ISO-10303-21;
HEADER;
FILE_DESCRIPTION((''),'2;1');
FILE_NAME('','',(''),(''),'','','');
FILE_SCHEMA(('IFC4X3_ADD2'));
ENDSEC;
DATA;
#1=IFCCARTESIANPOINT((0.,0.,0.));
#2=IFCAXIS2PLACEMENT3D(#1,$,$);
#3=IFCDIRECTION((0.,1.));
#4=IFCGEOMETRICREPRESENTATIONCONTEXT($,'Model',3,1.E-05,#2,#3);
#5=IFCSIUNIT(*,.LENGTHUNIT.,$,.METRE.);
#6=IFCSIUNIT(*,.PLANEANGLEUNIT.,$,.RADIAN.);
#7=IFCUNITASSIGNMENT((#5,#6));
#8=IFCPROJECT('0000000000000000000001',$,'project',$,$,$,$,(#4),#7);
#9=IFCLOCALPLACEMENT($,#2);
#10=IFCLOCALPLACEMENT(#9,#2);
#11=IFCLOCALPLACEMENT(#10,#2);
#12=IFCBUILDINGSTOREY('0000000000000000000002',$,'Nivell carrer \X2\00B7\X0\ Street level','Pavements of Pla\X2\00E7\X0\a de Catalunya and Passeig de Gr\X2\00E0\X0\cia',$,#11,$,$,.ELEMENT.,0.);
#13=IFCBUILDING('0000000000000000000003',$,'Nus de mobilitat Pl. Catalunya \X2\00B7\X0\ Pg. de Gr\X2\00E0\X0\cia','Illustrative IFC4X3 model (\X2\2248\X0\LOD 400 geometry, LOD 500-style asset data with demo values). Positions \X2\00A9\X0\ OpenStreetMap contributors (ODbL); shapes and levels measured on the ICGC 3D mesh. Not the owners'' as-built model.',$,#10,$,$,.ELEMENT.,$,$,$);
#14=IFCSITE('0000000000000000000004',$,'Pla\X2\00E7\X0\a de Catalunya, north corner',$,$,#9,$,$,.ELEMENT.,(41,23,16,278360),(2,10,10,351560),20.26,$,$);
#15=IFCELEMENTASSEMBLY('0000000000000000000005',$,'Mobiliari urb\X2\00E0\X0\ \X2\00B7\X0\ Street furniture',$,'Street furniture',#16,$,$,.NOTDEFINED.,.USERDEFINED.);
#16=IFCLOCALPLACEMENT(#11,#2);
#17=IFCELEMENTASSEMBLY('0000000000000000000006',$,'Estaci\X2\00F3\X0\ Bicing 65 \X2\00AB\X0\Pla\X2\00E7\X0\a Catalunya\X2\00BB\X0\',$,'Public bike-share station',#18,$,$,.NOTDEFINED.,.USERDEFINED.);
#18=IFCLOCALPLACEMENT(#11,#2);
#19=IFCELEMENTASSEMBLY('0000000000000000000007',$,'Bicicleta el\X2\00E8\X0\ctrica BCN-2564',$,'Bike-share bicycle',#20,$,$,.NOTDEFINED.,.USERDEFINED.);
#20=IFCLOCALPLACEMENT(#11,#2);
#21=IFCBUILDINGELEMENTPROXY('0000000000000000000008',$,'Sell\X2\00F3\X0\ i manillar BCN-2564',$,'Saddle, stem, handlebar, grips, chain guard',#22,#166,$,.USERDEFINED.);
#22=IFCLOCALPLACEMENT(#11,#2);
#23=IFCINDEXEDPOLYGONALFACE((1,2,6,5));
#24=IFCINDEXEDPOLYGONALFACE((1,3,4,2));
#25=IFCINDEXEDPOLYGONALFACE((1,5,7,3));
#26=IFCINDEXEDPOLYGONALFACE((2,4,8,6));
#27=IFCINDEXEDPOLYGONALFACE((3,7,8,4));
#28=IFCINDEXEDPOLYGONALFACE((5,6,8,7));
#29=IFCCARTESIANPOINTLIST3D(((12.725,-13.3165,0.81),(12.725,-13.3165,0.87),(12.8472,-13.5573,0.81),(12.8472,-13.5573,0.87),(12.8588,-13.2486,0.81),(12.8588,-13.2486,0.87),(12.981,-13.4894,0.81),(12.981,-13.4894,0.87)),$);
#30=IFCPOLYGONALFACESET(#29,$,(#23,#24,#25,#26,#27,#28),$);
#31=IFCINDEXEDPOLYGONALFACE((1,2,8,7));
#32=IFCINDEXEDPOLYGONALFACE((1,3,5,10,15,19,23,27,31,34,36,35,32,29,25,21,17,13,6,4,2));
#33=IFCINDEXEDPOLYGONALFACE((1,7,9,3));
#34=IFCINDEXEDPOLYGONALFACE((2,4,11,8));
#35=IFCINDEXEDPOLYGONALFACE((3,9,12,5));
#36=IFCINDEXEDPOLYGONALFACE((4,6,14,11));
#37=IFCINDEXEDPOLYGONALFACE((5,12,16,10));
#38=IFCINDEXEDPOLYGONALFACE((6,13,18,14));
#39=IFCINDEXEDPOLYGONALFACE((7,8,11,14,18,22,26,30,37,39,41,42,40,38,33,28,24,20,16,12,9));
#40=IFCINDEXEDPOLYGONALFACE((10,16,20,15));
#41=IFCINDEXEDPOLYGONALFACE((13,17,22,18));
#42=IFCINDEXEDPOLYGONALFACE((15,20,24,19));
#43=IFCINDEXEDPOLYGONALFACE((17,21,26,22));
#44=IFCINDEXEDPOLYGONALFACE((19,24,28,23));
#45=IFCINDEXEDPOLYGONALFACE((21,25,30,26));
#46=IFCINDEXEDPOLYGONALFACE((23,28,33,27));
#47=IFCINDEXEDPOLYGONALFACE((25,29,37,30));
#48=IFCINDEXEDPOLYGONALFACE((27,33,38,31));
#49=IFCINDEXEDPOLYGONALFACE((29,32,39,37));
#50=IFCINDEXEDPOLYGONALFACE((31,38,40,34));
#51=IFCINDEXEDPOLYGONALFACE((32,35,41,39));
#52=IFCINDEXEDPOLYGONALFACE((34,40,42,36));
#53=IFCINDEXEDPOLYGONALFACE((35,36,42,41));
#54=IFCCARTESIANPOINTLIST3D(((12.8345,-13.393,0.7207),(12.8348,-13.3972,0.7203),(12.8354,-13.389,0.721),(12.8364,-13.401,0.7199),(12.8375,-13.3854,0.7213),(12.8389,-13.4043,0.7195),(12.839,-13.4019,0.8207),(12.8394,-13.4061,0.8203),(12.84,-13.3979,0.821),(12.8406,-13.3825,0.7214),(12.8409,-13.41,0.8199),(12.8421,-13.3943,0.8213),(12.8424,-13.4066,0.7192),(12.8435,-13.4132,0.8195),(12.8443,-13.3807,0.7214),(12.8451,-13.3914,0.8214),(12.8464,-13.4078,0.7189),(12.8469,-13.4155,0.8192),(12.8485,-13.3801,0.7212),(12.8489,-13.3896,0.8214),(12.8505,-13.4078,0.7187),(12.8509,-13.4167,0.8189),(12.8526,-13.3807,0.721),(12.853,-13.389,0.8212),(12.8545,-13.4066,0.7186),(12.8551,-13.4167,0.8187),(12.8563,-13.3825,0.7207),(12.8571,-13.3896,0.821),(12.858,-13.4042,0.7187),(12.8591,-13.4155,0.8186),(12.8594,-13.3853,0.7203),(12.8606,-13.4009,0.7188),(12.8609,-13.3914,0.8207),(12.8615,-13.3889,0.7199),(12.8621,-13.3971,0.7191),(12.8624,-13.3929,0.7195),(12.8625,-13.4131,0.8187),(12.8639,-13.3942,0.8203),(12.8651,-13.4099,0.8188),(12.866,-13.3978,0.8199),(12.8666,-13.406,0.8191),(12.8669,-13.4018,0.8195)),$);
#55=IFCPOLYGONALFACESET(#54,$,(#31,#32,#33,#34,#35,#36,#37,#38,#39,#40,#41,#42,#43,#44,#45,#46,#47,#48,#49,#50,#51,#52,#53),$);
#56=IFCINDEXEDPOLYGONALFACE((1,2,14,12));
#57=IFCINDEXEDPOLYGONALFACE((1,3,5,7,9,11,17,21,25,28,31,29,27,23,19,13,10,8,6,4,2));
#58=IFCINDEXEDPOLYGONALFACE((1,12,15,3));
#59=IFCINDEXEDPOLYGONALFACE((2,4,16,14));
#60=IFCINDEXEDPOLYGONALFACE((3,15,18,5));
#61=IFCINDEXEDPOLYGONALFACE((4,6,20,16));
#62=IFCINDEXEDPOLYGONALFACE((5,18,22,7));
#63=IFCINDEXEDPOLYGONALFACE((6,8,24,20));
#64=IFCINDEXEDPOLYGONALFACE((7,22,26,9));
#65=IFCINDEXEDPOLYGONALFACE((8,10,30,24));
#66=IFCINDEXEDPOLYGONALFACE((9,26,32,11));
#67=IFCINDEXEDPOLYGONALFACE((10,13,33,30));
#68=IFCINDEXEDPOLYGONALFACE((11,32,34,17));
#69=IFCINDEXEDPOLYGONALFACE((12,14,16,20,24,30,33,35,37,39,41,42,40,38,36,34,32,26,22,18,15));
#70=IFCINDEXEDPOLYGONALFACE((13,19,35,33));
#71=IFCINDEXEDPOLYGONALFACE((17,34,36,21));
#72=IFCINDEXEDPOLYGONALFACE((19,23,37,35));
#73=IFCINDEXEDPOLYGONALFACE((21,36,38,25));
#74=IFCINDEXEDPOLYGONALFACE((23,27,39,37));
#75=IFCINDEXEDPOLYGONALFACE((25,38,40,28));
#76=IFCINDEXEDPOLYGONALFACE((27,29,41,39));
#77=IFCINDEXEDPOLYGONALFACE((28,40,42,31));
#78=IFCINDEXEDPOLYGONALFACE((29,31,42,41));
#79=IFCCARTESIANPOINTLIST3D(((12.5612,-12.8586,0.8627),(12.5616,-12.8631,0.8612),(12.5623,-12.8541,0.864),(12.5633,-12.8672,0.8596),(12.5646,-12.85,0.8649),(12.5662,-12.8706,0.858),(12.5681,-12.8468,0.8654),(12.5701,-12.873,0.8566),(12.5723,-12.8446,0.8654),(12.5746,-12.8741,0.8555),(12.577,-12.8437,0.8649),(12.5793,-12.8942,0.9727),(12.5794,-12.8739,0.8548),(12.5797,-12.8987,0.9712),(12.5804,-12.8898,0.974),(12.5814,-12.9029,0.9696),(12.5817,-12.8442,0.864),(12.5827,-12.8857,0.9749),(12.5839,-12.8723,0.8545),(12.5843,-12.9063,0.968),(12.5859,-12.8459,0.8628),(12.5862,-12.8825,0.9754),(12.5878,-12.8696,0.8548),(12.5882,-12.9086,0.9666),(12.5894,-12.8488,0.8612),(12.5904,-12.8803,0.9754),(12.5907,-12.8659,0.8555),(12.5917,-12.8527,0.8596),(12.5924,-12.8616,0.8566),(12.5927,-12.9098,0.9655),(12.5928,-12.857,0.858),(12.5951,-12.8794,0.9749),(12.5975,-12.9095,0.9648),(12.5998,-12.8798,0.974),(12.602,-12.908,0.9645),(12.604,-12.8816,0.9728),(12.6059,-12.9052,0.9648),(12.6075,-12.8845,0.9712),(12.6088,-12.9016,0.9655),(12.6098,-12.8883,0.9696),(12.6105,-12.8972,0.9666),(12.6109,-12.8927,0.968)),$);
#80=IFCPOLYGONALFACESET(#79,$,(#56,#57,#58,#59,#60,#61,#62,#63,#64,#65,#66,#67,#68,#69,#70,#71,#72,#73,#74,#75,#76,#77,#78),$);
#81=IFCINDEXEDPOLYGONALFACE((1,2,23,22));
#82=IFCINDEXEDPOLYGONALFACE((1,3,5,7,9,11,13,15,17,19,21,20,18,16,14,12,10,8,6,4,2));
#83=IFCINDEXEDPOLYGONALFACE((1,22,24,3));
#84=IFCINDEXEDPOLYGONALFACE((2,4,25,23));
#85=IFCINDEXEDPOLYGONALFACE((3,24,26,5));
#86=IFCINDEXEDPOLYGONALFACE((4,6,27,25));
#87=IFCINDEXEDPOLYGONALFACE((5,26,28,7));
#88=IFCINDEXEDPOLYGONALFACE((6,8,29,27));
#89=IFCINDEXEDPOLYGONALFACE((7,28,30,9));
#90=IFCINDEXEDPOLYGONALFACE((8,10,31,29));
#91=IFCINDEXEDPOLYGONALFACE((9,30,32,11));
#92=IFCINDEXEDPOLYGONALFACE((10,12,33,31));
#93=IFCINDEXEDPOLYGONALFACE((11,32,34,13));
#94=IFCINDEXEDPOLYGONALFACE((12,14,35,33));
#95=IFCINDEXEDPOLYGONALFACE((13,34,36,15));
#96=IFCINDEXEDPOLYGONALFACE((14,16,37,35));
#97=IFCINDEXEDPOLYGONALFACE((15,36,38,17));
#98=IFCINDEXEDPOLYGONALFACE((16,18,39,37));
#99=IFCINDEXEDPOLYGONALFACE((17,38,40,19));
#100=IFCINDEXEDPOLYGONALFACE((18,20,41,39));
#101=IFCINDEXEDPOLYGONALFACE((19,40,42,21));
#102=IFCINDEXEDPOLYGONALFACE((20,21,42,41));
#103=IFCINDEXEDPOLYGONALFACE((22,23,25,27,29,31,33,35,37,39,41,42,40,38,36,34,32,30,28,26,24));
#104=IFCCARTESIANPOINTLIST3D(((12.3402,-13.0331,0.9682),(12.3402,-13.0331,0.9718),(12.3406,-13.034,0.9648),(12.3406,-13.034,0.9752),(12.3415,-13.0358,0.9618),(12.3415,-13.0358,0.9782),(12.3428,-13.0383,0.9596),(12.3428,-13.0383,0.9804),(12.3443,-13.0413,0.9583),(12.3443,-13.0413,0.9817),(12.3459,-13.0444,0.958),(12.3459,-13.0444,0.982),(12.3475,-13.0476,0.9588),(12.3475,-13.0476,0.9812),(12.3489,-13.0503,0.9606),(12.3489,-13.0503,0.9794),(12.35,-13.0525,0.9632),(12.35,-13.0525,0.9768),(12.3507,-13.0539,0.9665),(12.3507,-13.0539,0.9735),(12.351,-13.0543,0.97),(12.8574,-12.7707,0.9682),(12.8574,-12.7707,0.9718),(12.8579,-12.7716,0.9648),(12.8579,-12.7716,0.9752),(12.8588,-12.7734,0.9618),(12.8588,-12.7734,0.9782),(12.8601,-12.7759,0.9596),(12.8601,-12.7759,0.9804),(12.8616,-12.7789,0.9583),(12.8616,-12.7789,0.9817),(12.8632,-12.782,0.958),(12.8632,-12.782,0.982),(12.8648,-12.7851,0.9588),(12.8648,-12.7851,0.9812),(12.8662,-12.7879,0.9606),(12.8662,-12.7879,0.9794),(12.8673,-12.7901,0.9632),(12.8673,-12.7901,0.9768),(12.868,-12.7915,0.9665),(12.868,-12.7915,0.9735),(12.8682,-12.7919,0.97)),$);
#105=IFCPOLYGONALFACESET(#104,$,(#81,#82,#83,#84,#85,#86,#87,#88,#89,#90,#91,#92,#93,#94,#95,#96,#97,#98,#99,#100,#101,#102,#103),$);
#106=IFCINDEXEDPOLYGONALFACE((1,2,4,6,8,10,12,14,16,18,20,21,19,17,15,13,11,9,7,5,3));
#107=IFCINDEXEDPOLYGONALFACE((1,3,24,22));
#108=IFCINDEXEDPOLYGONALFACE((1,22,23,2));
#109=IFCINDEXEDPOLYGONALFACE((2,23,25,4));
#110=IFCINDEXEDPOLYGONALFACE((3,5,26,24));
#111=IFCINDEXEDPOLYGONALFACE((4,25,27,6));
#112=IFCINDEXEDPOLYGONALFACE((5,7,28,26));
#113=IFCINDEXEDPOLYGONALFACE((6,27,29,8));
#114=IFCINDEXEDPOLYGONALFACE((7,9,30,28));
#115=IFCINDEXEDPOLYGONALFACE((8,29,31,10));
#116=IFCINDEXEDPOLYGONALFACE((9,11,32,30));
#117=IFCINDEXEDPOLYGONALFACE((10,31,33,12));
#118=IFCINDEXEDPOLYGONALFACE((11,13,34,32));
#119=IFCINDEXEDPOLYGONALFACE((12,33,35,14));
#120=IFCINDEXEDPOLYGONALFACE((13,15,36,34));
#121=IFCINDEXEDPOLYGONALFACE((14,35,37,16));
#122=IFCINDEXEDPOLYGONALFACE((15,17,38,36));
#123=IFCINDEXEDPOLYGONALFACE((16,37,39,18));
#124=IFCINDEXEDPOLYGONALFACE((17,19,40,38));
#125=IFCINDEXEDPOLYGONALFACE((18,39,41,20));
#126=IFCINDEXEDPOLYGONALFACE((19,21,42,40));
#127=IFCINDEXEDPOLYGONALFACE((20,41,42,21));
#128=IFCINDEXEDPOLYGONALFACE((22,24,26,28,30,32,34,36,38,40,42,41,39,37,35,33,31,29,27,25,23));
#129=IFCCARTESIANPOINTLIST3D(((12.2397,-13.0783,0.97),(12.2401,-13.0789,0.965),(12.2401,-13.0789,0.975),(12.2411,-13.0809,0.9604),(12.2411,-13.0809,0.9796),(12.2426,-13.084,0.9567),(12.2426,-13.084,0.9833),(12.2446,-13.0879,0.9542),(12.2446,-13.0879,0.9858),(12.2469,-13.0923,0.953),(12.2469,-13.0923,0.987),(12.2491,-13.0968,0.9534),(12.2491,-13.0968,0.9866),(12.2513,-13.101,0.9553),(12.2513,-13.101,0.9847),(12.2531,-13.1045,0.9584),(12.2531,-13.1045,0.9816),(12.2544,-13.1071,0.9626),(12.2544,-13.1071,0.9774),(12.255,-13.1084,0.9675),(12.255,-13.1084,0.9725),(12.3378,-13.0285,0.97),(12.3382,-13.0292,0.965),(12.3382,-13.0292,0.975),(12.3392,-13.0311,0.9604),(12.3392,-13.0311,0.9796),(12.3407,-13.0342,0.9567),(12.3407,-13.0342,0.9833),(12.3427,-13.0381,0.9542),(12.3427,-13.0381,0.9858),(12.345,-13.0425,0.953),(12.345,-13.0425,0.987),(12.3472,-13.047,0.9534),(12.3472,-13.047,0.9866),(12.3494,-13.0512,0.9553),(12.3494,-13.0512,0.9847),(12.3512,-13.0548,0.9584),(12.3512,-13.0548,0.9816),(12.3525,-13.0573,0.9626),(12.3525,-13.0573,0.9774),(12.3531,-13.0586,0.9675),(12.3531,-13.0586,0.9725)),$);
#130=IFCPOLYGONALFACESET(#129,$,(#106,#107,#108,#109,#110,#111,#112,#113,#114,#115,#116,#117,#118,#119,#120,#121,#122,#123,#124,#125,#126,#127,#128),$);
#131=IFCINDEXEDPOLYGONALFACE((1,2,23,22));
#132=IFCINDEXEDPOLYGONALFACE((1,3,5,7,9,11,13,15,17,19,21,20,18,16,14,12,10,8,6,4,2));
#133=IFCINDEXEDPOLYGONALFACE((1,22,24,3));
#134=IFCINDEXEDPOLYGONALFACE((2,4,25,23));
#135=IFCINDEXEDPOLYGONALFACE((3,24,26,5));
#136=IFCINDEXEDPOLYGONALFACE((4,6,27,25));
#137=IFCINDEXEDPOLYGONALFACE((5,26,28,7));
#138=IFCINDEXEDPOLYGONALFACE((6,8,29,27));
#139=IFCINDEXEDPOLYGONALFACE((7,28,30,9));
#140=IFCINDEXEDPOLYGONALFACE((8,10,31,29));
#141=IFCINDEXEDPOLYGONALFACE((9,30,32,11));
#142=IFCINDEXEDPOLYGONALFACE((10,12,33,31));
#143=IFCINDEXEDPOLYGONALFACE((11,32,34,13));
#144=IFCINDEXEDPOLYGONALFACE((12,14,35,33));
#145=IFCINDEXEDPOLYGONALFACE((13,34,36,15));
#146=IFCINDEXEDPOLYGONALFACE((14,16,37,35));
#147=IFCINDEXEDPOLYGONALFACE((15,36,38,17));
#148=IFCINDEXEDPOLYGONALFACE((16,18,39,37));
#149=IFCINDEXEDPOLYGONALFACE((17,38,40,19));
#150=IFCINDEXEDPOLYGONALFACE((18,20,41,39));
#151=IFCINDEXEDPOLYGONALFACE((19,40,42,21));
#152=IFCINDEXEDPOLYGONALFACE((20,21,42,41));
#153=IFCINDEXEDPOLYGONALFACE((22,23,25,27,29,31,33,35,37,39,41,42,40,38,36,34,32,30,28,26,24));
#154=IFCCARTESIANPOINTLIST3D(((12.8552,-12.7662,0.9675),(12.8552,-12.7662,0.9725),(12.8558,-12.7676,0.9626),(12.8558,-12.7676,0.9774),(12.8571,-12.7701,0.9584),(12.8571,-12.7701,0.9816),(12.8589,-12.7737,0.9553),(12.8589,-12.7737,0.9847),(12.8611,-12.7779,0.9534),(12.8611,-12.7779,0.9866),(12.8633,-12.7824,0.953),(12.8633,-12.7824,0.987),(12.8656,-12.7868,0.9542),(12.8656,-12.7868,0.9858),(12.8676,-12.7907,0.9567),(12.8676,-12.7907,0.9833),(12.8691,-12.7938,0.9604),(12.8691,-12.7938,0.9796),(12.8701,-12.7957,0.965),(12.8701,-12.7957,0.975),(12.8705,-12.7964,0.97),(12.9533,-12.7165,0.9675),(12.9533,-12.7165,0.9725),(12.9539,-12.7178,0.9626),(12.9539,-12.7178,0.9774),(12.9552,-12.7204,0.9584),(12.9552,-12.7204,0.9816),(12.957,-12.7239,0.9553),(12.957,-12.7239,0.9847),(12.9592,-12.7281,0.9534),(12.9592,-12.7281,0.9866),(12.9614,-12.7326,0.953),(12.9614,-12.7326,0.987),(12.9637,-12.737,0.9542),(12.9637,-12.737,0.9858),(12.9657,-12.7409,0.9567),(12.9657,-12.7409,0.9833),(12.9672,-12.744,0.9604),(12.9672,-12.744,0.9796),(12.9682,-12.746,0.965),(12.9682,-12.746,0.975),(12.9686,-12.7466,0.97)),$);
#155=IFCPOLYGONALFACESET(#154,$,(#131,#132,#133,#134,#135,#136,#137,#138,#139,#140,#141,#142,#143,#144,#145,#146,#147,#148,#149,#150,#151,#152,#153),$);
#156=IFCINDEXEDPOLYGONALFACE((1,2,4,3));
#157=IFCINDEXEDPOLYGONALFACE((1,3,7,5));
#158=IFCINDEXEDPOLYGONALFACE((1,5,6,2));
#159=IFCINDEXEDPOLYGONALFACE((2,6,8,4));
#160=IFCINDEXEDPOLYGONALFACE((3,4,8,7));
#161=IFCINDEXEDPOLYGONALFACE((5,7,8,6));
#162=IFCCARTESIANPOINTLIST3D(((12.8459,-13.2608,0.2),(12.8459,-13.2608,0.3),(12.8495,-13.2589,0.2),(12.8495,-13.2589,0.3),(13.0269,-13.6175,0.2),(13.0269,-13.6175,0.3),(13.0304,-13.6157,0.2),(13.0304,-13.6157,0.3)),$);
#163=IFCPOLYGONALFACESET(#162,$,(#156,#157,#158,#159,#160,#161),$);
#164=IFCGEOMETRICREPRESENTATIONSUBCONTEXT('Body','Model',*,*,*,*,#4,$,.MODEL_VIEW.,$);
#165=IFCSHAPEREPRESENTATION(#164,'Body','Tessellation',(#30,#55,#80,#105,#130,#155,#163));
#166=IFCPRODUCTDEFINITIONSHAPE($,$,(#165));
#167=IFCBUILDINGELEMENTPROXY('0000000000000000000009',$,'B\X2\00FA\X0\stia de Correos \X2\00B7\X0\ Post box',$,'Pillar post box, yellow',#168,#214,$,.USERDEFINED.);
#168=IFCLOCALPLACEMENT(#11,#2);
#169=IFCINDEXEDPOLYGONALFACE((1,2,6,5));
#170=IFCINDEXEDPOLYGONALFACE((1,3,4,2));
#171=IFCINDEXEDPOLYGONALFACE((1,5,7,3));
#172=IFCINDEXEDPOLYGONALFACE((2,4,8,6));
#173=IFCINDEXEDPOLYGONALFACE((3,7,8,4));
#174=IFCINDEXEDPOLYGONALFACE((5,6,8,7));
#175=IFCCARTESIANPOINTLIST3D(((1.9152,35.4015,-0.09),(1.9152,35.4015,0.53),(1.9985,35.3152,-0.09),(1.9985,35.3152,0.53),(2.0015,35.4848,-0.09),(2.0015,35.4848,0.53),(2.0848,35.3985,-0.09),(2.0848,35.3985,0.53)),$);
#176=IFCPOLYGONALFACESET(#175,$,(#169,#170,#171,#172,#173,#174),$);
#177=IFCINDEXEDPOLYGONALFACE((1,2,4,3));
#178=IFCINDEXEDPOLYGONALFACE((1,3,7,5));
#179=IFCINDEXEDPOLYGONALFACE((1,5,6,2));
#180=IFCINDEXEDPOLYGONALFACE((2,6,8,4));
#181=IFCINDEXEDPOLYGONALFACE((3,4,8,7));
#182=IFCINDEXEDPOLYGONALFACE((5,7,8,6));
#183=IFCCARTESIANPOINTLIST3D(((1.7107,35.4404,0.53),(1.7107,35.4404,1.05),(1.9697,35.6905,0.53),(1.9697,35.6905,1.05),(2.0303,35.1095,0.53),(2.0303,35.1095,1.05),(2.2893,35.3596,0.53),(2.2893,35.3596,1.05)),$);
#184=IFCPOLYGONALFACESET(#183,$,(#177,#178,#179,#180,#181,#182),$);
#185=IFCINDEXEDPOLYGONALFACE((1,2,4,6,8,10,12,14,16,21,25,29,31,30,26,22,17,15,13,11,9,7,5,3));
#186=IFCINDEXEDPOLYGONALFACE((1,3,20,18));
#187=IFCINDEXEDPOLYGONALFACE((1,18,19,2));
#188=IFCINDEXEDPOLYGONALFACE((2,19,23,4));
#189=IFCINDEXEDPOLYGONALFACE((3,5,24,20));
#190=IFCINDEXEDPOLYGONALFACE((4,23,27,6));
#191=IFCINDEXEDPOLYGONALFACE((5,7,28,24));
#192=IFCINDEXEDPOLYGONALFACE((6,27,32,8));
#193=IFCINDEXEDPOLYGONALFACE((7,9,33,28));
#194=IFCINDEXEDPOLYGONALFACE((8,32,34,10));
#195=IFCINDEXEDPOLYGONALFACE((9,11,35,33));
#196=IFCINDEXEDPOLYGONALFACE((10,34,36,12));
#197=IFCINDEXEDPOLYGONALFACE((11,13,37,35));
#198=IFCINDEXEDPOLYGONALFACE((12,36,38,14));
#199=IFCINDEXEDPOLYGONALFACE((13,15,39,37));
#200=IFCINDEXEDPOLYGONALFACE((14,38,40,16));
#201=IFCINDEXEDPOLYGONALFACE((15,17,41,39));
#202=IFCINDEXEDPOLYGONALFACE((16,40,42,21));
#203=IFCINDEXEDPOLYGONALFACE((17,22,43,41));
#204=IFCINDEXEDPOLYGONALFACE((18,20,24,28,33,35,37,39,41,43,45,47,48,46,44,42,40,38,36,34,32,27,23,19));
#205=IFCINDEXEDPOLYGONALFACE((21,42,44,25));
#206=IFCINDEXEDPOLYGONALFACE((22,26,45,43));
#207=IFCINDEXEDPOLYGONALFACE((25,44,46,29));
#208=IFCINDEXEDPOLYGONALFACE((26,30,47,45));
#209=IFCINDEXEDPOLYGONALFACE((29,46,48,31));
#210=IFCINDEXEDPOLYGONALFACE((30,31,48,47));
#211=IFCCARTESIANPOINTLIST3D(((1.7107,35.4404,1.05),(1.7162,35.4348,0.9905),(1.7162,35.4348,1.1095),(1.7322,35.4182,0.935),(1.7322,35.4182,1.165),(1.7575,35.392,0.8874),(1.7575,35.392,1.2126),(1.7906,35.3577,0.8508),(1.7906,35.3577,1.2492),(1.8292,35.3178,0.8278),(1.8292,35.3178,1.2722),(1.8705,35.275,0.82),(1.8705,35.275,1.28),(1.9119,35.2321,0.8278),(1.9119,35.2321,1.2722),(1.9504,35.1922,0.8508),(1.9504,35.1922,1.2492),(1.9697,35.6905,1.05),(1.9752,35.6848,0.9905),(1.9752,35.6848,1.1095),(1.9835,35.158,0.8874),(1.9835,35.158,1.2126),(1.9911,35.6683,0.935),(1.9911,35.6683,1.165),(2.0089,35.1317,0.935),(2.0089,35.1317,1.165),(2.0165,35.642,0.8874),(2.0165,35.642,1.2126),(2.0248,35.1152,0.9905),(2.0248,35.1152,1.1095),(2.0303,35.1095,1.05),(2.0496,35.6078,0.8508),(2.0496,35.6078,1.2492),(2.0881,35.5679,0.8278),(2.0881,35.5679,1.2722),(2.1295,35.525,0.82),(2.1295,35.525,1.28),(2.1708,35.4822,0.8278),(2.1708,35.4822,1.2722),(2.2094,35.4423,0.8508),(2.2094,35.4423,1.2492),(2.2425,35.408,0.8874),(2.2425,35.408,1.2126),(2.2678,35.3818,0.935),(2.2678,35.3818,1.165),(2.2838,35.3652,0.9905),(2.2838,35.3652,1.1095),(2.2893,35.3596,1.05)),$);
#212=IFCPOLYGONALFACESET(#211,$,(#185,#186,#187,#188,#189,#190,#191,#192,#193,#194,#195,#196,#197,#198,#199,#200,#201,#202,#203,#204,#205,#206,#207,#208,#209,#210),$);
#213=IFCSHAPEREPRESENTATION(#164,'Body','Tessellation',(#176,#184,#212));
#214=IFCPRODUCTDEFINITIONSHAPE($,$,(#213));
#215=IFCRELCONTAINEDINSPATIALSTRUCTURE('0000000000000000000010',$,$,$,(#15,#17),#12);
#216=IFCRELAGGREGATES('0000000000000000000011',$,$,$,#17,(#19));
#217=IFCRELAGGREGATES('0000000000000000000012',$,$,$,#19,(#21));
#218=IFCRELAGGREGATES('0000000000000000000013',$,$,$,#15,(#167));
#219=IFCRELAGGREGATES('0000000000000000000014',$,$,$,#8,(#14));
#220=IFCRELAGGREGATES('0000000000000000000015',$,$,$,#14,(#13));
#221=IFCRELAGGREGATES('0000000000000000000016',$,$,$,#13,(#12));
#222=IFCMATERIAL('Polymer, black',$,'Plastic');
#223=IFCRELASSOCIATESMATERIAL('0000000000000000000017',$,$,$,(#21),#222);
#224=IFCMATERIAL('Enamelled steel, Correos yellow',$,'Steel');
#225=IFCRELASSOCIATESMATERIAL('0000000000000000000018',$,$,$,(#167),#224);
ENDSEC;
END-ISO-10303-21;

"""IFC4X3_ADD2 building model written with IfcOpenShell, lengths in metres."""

from ifc_helpers import new_model, si_unit, direction, frame, frame_2d, origin, origin_2d_with_axis, place, context, subcontext, project, spatial, rectangle, circle, extrude, material, element, aggregate, save


model = new_model("IFC4X3_ADD2")

# Units and contexts
model_context = context("Model", 3, precision=1e-05, world=origin(), true_north=direction((0.0, 1.0)))
body_context = subcontext(model_context, "Body", "Model", "MODEL_VIEW")
ifc_project = project(units=[si_unit("LENGTHUNIT", "METRE"), si_unit("PLANEANGLEUNIT", "RADIAN")], contexts=[model_context])

# Site, building, storey
site_placement = place(None, origin())
site = spatial("IfcSite", under=ifc_project, at=site_placement, Name="Plaça de Catalunya, north corner", CompositionType="ELEMENT", RefLatitude=(41, 23, 16, 278360), RefLongitude=(2, 10, 10, 351560), RefElevation=20.26)
building_placement = place(site_placement, origin())
building = spatial("IfcBuilding", under=site, at=building_placement, Name="Nus de mobilitat Pl. Catalunya · Pg. de Gràcia", Description="Illustrative IFC4X3 model (≈LOD 400 geometry, LOD 500-style asset data with demo values). Positions © OpenStreetMap contributors (ODbL); shapes and levels measured on the ICGC 3D mesh. Not the owners' as-built model.", CompositionType="ELEMENT")
storey_placement = place(building_placement, origin())
storey = spatial("IfcBuildingStorey", under=building, at=storey_placement, Name="Nivell carrer · Street level", Description="Pavements of Plaça de Catalunya and Passeig de Gràcia", CompositionType="ELEMENT", Elevation=0.0)

# Element assembly
assembly_1_placement = place(building_placement, origin())
assembly_1 = element("IfcElementAssembly", 1, at=assembly_1_placement, inside=storey, Name="Mobiliari urbà · Street furniture", ObjectType="Street furniture", AssemblyPlace="NOTDEFINED", PredefinedType="USERDEFINED")

# Element assemblies
assembly_2_placement = place(building_placement, origin())
assembly_2 = element("IfcElementAssembly", 2, at=assembly_2_placement, inside=storey, Name="Estació Bicing 65 «Plaça Catalunya»", ObjectType="Public bike-share station", AssemblyPlace="NOTDEFINED", PredefinedType="USERDEFINED")
assembly_3_placement = place(building_placement, origin())
assembly_3 = element("IfcElementAssembly", 3, at=assembly_3_placement, Name="Bicicleta elèctrica BCN-2564", ObjectType="Bike-share bicycle", AssemblyPlace="NOTDEFINED", PredefinedType="USERDEFINED")
aggregate(assembly_2, [assembly_3])

# Building element proxies
ifc_material_1 = material(Name="Polymer, black", Category="Plastic")
proxy_1_placement = place(building_placement, origin())
proxy_1 = element("IfcBuildingElementProxy", 4, at=proxy_1_placement, material=ifc_material_1, Name="Selló i manillar BCN-2564", ObjectType="Saddle, stem, handlebar, grips, chain guard", PredefinedType="USERDEFINED", context=body_context, shape_type="SweptSolid", body=[
    extrude(rectangle(XDim=0.27, YDim=0.15, at=origin_2d_with_axis()), frame((12.853, -13.4029, 0.87), z_axis=(0.0, 0.0, -1.0), x_axis=(-0.452435, 0.891798, 0.0)), (0.0, 0.0, 1.0), 0.06),
    extrude(circle(Radius=0.014, at=origin_2d_with_axis()), frame((12.8485, -13.394, 0.72), z_axis=(0.045019, -0.088737, 0.995037), x_axis=(0.0, 0.996047, 0.088827)), (0.0, 0.0, 1.0), 0.1005),
    extrude(circle(Radius=0.016, at=origin_2d_with_axis()), frame((12.577, -12.8589, 0.86), z_axis=(0.154616, -0.304766, 0.939793), x_axis=(0.0, 0.951232, 0.308475)), (0.0, 0.0, 1.0), 0.117),
    extrude(circle(Radius=0.012, at=origin_2d_with_axis()), frame((12.3455, -13.0436, 0.97), z_axis=(0.891798, 0.452435, 0.0), x_axis=(0.452435, -0.891798, 0.0)), (0.0, 0.0, 1.0), 0.58),
    extrude(circle(Radius=0.017, at=origin_2d_with_axis()), frame((12.3455, -13.0436, 0.97), z_axis=(-0.891798, -0.452435, 0.0), x_axis=(-0.452435, 0.891798, 0.0)), (0.0, 0.0, 1.0), 0.11),
    extrude(circle(Radius=0.017, at=origin_2d_with_axis()), frame((12.8628, -12.7812, 0.97), z_axis=(0.891798, 0.452435, 0.0), x_axis=(0.452435, -0.891798, 0.0)), (0.0, 0.0, 1.0), 0.11),
    extrude(rectangle(XDim=0.4, YDim=0.1, at=origin_2d_with_axis()), frame((12.9364, -13.4391, 0.25), z_axis=(0.891798, 0.452435, 0.0), x_axis=(-0.452435, 0.891798, 0.0)), (0.0, 0.0, 1.0), 0.004),
])
aggregate(assembly_3, [proxy_1])
ifc_material_2 = material(Name="Enamelled steel, Correos yellow", Category="Steel")
proxy_2_placement = place(building_placement, origin())
proxy_2 = element("IfcBuildingElementProxy", 5, at=proxy_2_placement, material=ifc_material_2, Name="Bústia de Correos · Post box", ObjectType="Pillar post box, yellow", PredefinedType="USERDEFINED", context=body_context, shape_type="SweptSolid", body=[
    extrude(rectangle(XDim=0.12, YDim=0.12, at=frame_2d((0.0, 0.0), x_axis=(0.694658, -0.71934))), frame((2.0, 35.4, -0.09)), (0.0, 0.0, 1.0), 0.62),
    extrude(rectangle(XDim=0.46, YDim=0.36, at=frame_2d((0.0, 0.0), x_axis=(0.694658, -0.71934))), frame((2.0, 35.4, 0.53)), (0.0, 0.0, 1.0), 0.52),
    extrude(circle(Radius=0.23, at=origin_2d_with_axis()), frame((1.8705, 35.275, 1.05), z_axis=(0.71934, 0.694658, 0.0), x_axis=(0.694658, -0.71934, 0.0)), (0.0, 0.0, 1.0), 0.36),
])

aggregate(assembly_1, [proxy_2])

save(model, "model.ifc")
